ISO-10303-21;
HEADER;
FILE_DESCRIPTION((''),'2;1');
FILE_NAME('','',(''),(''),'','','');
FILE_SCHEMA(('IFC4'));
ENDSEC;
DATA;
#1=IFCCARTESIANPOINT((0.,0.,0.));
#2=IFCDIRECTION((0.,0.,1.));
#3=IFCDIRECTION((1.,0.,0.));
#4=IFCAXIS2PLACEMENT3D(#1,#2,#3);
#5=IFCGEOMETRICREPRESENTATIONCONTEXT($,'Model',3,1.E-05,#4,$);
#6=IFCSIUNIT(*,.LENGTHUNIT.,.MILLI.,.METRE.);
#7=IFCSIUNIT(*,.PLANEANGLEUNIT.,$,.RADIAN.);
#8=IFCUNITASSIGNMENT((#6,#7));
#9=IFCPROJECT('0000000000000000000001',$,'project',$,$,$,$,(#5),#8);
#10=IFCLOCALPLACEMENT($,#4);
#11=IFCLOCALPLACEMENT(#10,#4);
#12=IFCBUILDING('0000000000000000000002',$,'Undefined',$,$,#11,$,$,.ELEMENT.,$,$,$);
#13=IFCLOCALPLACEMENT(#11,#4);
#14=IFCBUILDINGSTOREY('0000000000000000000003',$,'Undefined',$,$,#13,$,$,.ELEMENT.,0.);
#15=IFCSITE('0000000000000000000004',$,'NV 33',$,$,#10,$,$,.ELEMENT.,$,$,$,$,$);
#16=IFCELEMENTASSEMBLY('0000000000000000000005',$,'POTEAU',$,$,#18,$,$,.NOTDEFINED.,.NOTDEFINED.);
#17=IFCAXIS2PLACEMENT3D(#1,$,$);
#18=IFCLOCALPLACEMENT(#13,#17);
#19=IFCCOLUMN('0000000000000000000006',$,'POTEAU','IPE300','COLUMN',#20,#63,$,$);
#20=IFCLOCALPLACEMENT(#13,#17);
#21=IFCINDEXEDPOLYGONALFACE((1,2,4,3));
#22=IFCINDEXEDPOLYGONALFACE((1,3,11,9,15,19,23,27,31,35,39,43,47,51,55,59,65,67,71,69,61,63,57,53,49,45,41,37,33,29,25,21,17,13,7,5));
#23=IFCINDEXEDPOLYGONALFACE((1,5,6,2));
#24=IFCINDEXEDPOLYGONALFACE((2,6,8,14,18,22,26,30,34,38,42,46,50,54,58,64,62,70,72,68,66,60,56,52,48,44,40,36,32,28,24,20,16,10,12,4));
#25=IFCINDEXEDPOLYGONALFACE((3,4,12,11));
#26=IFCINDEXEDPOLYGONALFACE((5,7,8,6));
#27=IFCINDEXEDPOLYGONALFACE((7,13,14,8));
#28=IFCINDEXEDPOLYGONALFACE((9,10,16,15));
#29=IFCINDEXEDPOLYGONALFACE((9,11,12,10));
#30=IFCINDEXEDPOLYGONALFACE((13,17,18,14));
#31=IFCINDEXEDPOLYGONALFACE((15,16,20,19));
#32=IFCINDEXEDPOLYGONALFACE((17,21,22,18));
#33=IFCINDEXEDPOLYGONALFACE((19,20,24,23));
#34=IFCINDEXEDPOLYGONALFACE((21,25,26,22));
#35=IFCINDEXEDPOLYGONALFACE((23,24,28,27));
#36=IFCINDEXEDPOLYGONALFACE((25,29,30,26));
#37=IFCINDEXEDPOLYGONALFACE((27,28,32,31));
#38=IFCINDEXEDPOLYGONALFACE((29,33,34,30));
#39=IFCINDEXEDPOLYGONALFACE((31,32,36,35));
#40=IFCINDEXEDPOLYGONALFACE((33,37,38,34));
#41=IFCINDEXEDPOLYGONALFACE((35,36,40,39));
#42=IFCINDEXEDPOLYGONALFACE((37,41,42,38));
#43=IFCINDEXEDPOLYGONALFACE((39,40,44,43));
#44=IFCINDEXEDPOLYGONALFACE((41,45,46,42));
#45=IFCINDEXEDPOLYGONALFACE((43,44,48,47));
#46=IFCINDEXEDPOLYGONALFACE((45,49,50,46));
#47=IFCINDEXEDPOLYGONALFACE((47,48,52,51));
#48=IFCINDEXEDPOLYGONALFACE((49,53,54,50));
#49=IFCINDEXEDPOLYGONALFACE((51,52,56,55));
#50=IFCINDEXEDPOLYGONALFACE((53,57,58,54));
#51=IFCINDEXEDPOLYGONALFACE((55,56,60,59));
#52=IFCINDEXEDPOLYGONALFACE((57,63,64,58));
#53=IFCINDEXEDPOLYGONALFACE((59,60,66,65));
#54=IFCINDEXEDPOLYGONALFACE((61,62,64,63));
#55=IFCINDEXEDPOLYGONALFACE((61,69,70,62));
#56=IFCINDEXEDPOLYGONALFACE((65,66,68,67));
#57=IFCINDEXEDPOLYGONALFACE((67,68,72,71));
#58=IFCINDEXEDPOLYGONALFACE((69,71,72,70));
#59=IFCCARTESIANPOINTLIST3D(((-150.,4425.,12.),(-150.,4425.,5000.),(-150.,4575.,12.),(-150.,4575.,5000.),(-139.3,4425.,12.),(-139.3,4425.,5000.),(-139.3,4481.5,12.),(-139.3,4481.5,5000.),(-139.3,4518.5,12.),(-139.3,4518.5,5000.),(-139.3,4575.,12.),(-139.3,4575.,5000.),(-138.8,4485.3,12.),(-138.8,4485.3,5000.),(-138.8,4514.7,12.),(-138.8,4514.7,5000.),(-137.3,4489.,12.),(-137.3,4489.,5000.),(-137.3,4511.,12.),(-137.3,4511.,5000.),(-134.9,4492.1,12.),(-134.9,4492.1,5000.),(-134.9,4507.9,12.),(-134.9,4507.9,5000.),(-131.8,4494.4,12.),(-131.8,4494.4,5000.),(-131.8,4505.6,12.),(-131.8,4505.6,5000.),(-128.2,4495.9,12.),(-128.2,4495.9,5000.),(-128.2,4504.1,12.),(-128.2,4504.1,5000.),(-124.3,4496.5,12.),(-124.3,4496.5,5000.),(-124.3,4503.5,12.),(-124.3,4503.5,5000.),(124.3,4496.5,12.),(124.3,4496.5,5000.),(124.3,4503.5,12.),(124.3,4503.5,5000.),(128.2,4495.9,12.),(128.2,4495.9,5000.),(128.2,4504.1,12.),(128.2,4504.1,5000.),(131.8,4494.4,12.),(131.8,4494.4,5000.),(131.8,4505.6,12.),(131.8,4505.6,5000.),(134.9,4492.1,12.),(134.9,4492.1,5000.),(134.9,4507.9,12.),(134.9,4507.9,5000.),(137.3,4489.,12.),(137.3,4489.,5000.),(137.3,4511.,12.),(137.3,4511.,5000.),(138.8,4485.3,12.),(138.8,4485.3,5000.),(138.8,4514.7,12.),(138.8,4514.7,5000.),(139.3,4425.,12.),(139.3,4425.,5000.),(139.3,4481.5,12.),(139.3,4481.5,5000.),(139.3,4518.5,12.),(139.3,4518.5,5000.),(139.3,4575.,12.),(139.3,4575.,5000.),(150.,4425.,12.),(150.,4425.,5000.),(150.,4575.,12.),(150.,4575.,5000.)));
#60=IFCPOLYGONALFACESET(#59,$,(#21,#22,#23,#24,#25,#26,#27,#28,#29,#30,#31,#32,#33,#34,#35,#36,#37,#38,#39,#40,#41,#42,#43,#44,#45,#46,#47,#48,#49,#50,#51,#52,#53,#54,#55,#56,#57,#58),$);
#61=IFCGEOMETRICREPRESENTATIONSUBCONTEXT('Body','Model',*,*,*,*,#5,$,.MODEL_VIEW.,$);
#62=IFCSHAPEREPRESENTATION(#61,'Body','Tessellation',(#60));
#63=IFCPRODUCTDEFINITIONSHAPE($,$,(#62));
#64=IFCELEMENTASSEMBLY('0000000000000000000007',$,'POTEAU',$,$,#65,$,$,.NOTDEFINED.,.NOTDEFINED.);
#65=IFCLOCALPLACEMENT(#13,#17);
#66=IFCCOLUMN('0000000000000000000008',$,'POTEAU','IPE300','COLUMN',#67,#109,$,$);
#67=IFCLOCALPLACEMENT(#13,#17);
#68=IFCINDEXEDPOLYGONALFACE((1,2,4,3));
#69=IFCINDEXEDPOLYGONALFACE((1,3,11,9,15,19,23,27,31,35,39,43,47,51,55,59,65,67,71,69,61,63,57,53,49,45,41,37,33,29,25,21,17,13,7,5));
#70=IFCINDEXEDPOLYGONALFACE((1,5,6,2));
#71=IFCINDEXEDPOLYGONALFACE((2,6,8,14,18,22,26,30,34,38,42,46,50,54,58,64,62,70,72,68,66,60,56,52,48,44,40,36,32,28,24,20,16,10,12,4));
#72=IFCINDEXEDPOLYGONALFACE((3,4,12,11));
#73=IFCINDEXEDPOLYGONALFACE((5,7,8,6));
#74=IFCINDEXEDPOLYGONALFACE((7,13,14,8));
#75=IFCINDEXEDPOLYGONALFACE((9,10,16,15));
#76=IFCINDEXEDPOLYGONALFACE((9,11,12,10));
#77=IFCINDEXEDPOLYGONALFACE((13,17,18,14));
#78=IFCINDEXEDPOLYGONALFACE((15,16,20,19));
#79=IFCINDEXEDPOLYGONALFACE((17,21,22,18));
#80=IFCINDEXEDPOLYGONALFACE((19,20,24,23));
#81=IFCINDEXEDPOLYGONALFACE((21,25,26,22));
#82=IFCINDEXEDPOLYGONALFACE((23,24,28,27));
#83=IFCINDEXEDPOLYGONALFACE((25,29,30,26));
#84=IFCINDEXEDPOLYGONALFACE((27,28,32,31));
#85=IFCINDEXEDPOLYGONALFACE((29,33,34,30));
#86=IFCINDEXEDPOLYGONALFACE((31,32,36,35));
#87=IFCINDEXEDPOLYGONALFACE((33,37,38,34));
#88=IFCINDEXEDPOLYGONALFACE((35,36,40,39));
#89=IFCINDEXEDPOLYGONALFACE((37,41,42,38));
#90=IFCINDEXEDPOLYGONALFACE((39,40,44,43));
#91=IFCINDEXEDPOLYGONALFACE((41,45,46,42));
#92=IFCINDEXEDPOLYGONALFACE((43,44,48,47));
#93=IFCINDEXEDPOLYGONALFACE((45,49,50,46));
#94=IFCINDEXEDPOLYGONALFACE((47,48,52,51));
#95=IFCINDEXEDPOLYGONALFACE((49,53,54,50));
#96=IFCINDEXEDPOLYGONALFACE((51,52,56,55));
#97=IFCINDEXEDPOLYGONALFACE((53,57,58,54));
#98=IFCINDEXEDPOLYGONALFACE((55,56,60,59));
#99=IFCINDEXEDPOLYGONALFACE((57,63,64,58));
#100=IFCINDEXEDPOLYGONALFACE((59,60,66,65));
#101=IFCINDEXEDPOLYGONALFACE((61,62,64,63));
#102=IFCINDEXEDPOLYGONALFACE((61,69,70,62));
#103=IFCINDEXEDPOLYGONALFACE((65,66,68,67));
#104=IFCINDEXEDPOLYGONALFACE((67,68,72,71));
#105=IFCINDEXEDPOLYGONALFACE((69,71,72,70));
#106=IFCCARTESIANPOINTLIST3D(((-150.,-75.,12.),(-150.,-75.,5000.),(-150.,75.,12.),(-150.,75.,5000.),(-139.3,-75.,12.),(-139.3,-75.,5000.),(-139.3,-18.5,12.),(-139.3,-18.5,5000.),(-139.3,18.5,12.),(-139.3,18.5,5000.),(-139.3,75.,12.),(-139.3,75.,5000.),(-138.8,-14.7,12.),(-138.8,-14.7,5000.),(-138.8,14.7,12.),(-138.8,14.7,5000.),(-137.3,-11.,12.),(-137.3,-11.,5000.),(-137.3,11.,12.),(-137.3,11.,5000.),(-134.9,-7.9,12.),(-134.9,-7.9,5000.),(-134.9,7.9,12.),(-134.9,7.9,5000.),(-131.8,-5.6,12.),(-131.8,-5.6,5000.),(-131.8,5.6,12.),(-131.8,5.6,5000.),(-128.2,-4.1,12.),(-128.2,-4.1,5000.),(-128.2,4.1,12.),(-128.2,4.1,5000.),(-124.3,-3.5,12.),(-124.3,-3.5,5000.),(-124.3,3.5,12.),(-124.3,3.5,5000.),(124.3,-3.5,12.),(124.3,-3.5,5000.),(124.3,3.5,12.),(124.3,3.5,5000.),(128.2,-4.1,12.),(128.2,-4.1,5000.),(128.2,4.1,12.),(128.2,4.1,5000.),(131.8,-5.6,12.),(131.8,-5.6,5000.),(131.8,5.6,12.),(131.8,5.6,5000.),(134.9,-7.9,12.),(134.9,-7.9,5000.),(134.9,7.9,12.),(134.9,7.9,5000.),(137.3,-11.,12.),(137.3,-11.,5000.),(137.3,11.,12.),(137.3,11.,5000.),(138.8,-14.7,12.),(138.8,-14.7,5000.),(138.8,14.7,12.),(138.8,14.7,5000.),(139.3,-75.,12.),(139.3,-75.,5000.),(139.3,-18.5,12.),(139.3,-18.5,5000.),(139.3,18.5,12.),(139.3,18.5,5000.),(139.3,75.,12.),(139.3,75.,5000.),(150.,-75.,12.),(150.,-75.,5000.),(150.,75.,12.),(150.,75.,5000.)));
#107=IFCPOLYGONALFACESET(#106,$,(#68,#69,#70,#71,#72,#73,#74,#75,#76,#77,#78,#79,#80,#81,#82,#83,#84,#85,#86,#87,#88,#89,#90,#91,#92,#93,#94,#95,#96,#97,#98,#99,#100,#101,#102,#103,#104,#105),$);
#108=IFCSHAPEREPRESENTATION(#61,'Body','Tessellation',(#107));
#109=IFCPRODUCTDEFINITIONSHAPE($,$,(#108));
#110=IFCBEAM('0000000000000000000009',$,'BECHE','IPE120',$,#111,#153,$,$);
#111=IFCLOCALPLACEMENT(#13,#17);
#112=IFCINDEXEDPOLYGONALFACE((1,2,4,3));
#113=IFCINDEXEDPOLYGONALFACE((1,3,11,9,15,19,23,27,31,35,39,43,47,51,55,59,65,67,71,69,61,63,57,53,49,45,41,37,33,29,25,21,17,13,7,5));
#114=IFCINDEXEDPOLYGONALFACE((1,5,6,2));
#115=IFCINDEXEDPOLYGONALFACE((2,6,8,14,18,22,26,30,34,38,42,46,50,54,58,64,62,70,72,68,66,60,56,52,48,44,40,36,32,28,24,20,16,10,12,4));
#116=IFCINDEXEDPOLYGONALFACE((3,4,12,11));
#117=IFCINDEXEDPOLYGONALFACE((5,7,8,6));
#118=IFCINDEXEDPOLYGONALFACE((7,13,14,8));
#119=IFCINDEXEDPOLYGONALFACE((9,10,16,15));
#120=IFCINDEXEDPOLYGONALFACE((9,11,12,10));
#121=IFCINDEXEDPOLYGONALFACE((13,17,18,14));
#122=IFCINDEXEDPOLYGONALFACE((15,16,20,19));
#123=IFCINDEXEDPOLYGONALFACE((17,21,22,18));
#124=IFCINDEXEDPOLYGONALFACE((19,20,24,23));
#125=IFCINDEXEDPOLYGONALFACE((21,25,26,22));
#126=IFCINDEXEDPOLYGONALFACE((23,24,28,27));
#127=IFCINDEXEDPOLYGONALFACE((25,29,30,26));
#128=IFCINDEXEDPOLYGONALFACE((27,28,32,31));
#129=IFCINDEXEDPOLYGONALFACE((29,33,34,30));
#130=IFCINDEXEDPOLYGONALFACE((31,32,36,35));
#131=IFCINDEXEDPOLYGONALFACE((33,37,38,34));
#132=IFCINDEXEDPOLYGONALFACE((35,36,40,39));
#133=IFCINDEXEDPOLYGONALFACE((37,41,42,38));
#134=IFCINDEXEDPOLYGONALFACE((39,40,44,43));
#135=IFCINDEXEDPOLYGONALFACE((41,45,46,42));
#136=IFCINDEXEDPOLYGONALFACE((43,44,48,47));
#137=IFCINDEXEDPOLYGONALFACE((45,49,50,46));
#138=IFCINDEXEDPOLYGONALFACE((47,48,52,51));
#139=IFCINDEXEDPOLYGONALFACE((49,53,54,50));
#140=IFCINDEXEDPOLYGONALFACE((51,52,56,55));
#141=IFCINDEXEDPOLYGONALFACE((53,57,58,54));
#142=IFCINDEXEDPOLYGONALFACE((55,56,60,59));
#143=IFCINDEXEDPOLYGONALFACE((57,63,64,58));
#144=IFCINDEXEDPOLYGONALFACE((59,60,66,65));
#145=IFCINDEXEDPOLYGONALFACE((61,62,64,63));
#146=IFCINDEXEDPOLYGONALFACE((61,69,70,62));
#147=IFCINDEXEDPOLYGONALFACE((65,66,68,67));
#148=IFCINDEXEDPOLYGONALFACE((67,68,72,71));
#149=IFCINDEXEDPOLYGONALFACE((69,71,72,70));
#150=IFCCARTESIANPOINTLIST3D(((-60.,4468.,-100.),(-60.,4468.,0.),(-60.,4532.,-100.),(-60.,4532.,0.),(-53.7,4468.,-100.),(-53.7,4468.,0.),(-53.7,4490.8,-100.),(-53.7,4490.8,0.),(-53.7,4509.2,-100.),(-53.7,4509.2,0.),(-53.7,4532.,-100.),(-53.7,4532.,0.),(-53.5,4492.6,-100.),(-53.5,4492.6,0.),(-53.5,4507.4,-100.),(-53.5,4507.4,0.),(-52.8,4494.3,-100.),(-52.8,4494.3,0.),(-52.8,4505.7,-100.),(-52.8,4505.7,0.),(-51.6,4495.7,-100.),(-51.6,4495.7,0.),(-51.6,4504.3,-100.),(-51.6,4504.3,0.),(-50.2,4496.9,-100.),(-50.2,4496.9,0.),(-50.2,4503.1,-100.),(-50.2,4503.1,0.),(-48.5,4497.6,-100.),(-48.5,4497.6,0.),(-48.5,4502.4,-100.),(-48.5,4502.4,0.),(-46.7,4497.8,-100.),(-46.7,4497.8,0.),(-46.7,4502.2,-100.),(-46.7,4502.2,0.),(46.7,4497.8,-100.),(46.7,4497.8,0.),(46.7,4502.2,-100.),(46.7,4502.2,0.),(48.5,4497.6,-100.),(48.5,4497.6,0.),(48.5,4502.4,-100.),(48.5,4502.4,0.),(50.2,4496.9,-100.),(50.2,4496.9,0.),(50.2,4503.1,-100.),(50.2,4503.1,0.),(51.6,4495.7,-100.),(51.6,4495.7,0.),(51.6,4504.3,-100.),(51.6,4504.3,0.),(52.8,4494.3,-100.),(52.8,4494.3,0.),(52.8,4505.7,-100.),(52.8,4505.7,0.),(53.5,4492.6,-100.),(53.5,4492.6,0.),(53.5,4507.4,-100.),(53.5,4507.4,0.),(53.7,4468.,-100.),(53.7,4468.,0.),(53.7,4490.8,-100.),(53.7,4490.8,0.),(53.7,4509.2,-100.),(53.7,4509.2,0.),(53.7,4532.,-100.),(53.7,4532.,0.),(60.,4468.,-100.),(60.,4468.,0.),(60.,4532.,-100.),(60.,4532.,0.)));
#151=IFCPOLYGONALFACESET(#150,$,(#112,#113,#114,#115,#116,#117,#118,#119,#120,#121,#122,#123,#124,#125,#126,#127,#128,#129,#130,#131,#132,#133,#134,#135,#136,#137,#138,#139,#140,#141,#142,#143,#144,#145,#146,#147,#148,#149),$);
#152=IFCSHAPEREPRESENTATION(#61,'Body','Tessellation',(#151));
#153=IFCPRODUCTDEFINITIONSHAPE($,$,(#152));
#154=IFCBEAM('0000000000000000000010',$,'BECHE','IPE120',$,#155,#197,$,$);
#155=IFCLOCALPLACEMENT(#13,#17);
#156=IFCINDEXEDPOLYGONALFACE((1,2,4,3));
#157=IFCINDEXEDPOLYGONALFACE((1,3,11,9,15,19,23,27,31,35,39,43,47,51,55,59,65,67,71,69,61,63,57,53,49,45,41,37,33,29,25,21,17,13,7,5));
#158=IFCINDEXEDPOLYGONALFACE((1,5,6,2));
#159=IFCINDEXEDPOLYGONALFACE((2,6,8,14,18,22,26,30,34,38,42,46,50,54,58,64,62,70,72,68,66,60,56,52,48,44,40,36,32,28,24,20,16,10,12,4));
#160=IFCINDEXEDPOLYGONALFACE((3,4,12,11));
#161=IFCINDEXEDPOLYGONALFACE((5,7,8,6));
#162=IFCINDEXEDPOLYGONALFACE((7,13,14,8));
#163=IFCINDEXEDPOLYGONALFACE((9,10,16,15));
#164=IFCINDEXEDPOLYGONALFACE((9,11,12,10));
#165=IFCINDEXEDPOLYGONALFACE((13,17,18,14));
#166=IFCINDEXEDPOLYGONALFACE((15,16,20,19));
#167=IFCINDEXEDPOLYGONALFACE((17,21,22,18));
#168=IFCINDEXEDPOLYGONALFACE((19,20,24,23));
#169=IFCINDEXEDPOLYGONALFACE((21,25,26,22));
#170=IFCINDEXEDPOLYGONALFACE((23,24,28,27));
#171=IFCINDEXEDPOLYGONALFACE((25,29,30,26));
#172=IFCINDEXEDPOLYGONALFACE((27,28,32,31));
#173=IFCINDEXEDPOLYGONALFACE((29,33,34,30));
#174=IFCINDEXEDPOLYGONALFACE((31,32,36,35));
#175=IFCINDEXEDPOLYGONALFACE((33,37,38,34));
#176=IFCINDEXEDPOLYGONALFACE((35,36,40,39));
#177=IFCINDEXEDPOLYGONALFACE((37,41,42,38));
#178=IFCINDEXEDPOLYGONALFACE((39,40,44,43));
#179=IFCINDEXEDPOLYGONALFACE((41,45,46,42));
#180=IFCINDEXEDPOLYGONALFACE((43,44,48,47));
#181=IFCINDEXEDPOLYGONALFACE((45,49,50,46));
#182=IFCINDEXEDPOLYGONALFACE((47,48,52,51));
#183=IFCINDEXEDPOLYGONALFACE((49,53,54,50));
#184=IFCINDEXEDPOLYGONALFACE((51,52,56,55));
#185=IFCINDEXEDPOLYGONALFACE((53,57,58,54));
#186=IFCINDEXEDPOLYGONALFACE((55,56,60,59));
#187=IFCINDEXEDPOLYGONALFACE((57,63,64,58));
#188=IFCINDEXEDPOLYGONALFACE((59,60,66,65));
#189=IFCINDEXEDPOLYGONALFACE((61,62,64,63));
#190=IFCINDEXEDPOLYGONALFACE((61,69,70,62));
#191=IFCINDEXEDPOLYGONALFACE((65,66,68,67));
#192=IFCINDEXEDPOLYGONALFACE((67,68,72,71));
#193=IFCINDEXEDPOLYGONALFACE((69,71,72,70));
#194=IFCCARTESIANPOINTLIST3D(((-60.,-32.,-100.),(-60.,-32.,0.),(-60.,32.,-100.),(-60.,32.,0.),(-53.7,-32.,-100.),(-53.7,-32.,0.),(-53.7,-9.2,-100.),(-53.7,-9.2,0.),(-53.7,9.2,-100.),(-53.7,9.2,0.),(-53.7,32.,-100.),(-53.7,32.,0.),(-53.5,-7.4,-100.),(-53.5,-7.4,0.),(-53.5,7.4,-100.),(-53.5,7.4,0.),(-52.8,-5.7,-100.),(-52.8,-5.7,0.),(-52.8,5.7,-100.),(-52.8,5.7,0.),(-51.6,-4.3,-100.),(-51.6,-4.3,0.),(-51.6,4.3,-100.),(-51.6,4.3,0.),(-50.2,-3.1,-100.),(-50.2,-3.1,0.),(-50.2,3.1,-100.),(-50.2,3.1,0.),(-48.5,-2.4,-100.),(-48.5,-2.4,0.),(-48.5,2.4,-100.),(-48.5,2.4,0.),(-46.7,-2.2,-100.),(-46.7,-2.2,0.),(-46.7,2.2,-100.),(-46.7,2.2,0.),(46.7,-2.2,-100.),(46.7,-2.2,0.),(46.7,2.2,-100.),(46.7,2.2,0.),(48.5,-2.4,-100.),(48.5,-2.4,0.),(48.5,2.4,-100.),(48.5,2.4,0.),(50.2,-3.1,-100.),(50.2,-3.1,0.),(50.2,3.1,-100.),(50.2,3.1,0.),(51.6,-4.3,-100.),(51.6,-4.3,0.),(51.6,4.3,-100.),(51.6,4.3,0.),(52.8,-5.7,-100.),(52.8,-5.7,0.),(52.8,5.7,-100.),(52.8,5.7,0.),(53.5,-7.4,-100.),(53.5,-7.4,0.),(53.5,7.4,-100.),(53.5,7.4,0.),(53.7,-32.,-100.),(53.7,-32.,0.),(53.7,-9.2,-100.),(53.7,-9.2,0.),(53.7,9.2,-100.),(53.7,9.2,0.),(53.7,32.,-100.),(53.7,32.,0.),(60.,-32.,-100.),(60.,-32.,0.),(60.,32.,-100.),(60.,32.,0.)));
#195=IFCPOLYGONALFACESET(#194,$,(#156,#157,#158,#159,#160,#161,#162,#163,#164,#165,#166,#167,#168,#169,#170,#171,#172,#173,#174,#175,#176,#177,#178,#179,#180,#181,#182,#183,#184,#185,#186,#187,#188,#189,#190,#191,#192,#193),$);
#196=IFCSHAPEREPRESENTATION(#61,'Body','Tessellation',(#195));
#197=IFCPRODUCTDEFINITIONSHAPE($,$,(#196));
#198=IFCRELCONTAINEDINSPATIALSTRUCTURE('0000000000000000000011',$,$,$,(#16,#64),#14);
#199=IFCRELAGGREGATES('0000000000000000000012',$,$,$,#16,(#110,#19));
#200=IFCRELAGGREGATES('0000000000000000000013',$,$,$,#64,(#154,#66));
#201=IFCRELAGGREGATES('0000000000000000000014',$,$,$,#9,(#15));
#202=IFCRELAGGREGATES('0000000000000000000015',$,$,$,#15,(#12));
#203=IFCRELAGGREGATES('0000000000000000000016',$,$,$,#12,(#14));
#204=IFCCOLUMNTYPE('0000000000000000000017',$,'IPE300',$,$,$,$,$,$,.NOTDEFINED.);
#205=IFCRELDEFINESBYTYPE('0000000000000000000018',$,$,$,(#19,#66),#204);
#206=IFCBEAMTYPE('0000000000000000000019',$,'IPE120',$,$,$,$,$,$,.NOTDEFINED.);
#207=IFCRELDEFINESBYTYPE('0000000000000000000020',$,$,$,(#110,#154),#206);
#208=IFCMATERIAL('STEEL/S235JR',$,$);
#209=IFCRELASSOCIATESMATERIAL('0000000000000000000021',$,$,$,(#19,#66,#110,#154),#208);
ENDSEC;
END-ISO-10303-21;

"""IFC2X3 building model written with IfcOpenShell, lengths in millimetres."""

from ifc_helpers import new_model, si_unit, frame, origin_with_axes, origin_2d_with_axis, place, context, subcontext, project, spatial, i_section, extrude, clip, halfspace, material, type_object, element, aggregate, save


model = new_model("IFC2X3")

# Units and contexts
model_context = context("Model", 3, precision=1e-05, world=origin_with_axes())
body_context = subcontext(model_context, "Body", "Model", "MODEL_VIEW")
ifc_project = project(units=[si_unit("LENGTHUNIT", "METRE", prefix="MILLI"), si_unit("PLANEANGLEUNIT", "RADIAN")], contexts=[model_context])

# Site, building, storey
site_placement = place(None, origin_with_axes())
site = spatial("IfcSite", under=ifc_project, at=site_placement, Name="NV 33", CompositionType="ELEMENT")
building_placement = place(site_placement, origin_with_axes())
building = spatial("IfcBuilding", under=site, at=building_placement, Name="Undefined", CompositionType="ELEMENT")
storey_placement = place(building_placement, origin_with_axes())
storey = spatial("IfcBuildingStorey", under=building, at=storey_placement, Name="Undefined", CompositionType="ELEMENT", Elevation=0.0)

# Element assemblies, columns
assembly_1_placement = place(storey_placement, origin_with_axes())
assembly_1 = element("IfcElementAssembly", 1, at=assembly_1_placement, inside=storey, Name="POTEAU", AssemblyPlace="NOTDEFINED", PredefinedType="NOTDEFINED")
ifc_material = material(Name="STEEL/S235JR")
column_type = type_object("IfcColumnType", Name="IPE300", PredefinedType="NOTDEFINED")
column_1_placement = place(assembly_1_placement, frame((0.0, 4500.0, 0.0), z_axis=(0.0, 0.0, 1.0), x_axis=(-1.0, 0.0, 0.0)))
column_1 = element("IfcColumn", 2, at=column_1_placement, type_object=column_type, material=ifc_material, Name="POTEAU", Description="IPE300", ObjectType="COLUMN", context=body_context, shape_type="Clipping", body=[
    clip(clip(extrude(i_section(OverallWidth=150.0, OverallDepth=300.0, WebThickness=7.1, FlangeThickness=10.7, FilletRadius=15.0, at=origin_2d_with_axis()), frame((0.0, 0.0, 5000.0), z_axis=(0.0, 0.0, -1.0), x_axis=(0.0, 1.0, 0.0)), (0.0, 0.0, 1.0), 5000.0), halfspace(frame((-150.0, 0.0, 5000.0), z_axis=(0.0, 0.0, -1.0), x_axis=(0.0, -1.0, 0.0)), True)), halfspace(frame((-150.0, 0.0, 12.0), z_axis=(0.0, 0.0, 1.0), x_axis=(0.0, 1.0, 0.0)), True)),
])
assembly_2_placement = place(storey_placement, origin_with_axes())
assembly_2 = element("IfcElementAssembly", 3, at=assembly_2_placement, inside=storey, Name="POTEAU", AssemblyPlace="NOTDEFINED", PredefinedType="NOTDEFINED")
column_2_placement = place(assembly_2_placement, frame((0.0, 0.0, 0.0), z_axis=(0.0, 0.0, 1.0), x_axis=(-1.0, 0.0, 0.0)))
column_2 = element("IfcColumn", 4, at=column_2_placement, type_object=column_type, material=ifc_material, Name="POTEAU", Description="IPE300", ObjectType="COLUMN", context=body_context, shape_type="Clipping", body=[
    clip(clip(extrude(i_section(OverallWidth=150.0, OverallDepth=300.0, WebThickness=7.1, FlangeThickness=10.7, FilletRadius=15.0, at=origin_2d_with_axis()), frame((0.0, 0.0, 5000.0), z_axis=(0.0, 0.0, -1.0), x_axis=(0.0, 1.0, 0.0)), (0.0, 0.0, 1.0), 5000.0), halfspace(frame((-150.0, 0.0, 5000.0), z_axis=(0.0, 0.0, -1.0), x_axis=(0.0, -1.0, 0.0)), True)), halfspace(frame((-150.0, 0.0, 12.0), z_axis=(0.0, 0.0, 1.0), x_axis=(0.0, 1.0, 0.0)), True)),
])

# Beams
beam_type_1 = type_object("IfcBeamType", Name="IPE120", PredefinedType="NOTDEFINED")
beam_1_placement = place(assembly_1_placement, frame((0.0, 4500.0, 0.0), z_axis=(-1.0, 0.0, 0.0), x_axis=(0.0, 0.0, -1.0)))
beam_1 = element("IfcBeam", 5, at=beam_1_placement, type_object=beam_type_1, material=ifc_material, Name="BECHE", Description="IPE120", context=body_context, shape_type="SweptSolid", body=[
    extrude(i_section(OverallWidth=64.0, OverallDepth=120.0, WebThickness=4.4, FlangeThickness=6.3, FilletRadius=7.0, at=origin_2d_with_axis()), frame((100.0, 0.0, 0.0), z_axis=(-1.0, 0.0, 0.0), x_axis=(0.0, -1.0, 0.0)), (0.0, 0.0, 1.0), 100.0),
])
beam_2_placement = place(assembly_2_placement, frame((0.0, 0.0, 0.0), z_axis=(-1.0, 0.0, 0.0), x_axis=(0.0, 0.0, -1.0)))
beam_2 = element("IfcBeam", 6, at=beam_2_placement, type_object=beam_type_1, material=ifc_material, Name="BECHE", Description="IPE120", context=body_context, shape_type="SweptSolid", body=[
    extrude(i_section(OverallWidth=64.0, OverallDepth=120.0, WebThickness=4.4, FlangeThickness=6.3, FilletRadius=7.0, at=origin_2d_with_axis()), frame((100.0, 0.0, 0.0), z_axis=(-1.0, 0.0, 0.0), x_axis=(0.0, -1.0, 0.0)), (0.0, 0.0, 1.0), 100.0),
])

aggregate(assembly_1, [beam_1, column_1])
aggregate(assembly_2, [beam_2, column_2])

save(model, "model.ifc")
